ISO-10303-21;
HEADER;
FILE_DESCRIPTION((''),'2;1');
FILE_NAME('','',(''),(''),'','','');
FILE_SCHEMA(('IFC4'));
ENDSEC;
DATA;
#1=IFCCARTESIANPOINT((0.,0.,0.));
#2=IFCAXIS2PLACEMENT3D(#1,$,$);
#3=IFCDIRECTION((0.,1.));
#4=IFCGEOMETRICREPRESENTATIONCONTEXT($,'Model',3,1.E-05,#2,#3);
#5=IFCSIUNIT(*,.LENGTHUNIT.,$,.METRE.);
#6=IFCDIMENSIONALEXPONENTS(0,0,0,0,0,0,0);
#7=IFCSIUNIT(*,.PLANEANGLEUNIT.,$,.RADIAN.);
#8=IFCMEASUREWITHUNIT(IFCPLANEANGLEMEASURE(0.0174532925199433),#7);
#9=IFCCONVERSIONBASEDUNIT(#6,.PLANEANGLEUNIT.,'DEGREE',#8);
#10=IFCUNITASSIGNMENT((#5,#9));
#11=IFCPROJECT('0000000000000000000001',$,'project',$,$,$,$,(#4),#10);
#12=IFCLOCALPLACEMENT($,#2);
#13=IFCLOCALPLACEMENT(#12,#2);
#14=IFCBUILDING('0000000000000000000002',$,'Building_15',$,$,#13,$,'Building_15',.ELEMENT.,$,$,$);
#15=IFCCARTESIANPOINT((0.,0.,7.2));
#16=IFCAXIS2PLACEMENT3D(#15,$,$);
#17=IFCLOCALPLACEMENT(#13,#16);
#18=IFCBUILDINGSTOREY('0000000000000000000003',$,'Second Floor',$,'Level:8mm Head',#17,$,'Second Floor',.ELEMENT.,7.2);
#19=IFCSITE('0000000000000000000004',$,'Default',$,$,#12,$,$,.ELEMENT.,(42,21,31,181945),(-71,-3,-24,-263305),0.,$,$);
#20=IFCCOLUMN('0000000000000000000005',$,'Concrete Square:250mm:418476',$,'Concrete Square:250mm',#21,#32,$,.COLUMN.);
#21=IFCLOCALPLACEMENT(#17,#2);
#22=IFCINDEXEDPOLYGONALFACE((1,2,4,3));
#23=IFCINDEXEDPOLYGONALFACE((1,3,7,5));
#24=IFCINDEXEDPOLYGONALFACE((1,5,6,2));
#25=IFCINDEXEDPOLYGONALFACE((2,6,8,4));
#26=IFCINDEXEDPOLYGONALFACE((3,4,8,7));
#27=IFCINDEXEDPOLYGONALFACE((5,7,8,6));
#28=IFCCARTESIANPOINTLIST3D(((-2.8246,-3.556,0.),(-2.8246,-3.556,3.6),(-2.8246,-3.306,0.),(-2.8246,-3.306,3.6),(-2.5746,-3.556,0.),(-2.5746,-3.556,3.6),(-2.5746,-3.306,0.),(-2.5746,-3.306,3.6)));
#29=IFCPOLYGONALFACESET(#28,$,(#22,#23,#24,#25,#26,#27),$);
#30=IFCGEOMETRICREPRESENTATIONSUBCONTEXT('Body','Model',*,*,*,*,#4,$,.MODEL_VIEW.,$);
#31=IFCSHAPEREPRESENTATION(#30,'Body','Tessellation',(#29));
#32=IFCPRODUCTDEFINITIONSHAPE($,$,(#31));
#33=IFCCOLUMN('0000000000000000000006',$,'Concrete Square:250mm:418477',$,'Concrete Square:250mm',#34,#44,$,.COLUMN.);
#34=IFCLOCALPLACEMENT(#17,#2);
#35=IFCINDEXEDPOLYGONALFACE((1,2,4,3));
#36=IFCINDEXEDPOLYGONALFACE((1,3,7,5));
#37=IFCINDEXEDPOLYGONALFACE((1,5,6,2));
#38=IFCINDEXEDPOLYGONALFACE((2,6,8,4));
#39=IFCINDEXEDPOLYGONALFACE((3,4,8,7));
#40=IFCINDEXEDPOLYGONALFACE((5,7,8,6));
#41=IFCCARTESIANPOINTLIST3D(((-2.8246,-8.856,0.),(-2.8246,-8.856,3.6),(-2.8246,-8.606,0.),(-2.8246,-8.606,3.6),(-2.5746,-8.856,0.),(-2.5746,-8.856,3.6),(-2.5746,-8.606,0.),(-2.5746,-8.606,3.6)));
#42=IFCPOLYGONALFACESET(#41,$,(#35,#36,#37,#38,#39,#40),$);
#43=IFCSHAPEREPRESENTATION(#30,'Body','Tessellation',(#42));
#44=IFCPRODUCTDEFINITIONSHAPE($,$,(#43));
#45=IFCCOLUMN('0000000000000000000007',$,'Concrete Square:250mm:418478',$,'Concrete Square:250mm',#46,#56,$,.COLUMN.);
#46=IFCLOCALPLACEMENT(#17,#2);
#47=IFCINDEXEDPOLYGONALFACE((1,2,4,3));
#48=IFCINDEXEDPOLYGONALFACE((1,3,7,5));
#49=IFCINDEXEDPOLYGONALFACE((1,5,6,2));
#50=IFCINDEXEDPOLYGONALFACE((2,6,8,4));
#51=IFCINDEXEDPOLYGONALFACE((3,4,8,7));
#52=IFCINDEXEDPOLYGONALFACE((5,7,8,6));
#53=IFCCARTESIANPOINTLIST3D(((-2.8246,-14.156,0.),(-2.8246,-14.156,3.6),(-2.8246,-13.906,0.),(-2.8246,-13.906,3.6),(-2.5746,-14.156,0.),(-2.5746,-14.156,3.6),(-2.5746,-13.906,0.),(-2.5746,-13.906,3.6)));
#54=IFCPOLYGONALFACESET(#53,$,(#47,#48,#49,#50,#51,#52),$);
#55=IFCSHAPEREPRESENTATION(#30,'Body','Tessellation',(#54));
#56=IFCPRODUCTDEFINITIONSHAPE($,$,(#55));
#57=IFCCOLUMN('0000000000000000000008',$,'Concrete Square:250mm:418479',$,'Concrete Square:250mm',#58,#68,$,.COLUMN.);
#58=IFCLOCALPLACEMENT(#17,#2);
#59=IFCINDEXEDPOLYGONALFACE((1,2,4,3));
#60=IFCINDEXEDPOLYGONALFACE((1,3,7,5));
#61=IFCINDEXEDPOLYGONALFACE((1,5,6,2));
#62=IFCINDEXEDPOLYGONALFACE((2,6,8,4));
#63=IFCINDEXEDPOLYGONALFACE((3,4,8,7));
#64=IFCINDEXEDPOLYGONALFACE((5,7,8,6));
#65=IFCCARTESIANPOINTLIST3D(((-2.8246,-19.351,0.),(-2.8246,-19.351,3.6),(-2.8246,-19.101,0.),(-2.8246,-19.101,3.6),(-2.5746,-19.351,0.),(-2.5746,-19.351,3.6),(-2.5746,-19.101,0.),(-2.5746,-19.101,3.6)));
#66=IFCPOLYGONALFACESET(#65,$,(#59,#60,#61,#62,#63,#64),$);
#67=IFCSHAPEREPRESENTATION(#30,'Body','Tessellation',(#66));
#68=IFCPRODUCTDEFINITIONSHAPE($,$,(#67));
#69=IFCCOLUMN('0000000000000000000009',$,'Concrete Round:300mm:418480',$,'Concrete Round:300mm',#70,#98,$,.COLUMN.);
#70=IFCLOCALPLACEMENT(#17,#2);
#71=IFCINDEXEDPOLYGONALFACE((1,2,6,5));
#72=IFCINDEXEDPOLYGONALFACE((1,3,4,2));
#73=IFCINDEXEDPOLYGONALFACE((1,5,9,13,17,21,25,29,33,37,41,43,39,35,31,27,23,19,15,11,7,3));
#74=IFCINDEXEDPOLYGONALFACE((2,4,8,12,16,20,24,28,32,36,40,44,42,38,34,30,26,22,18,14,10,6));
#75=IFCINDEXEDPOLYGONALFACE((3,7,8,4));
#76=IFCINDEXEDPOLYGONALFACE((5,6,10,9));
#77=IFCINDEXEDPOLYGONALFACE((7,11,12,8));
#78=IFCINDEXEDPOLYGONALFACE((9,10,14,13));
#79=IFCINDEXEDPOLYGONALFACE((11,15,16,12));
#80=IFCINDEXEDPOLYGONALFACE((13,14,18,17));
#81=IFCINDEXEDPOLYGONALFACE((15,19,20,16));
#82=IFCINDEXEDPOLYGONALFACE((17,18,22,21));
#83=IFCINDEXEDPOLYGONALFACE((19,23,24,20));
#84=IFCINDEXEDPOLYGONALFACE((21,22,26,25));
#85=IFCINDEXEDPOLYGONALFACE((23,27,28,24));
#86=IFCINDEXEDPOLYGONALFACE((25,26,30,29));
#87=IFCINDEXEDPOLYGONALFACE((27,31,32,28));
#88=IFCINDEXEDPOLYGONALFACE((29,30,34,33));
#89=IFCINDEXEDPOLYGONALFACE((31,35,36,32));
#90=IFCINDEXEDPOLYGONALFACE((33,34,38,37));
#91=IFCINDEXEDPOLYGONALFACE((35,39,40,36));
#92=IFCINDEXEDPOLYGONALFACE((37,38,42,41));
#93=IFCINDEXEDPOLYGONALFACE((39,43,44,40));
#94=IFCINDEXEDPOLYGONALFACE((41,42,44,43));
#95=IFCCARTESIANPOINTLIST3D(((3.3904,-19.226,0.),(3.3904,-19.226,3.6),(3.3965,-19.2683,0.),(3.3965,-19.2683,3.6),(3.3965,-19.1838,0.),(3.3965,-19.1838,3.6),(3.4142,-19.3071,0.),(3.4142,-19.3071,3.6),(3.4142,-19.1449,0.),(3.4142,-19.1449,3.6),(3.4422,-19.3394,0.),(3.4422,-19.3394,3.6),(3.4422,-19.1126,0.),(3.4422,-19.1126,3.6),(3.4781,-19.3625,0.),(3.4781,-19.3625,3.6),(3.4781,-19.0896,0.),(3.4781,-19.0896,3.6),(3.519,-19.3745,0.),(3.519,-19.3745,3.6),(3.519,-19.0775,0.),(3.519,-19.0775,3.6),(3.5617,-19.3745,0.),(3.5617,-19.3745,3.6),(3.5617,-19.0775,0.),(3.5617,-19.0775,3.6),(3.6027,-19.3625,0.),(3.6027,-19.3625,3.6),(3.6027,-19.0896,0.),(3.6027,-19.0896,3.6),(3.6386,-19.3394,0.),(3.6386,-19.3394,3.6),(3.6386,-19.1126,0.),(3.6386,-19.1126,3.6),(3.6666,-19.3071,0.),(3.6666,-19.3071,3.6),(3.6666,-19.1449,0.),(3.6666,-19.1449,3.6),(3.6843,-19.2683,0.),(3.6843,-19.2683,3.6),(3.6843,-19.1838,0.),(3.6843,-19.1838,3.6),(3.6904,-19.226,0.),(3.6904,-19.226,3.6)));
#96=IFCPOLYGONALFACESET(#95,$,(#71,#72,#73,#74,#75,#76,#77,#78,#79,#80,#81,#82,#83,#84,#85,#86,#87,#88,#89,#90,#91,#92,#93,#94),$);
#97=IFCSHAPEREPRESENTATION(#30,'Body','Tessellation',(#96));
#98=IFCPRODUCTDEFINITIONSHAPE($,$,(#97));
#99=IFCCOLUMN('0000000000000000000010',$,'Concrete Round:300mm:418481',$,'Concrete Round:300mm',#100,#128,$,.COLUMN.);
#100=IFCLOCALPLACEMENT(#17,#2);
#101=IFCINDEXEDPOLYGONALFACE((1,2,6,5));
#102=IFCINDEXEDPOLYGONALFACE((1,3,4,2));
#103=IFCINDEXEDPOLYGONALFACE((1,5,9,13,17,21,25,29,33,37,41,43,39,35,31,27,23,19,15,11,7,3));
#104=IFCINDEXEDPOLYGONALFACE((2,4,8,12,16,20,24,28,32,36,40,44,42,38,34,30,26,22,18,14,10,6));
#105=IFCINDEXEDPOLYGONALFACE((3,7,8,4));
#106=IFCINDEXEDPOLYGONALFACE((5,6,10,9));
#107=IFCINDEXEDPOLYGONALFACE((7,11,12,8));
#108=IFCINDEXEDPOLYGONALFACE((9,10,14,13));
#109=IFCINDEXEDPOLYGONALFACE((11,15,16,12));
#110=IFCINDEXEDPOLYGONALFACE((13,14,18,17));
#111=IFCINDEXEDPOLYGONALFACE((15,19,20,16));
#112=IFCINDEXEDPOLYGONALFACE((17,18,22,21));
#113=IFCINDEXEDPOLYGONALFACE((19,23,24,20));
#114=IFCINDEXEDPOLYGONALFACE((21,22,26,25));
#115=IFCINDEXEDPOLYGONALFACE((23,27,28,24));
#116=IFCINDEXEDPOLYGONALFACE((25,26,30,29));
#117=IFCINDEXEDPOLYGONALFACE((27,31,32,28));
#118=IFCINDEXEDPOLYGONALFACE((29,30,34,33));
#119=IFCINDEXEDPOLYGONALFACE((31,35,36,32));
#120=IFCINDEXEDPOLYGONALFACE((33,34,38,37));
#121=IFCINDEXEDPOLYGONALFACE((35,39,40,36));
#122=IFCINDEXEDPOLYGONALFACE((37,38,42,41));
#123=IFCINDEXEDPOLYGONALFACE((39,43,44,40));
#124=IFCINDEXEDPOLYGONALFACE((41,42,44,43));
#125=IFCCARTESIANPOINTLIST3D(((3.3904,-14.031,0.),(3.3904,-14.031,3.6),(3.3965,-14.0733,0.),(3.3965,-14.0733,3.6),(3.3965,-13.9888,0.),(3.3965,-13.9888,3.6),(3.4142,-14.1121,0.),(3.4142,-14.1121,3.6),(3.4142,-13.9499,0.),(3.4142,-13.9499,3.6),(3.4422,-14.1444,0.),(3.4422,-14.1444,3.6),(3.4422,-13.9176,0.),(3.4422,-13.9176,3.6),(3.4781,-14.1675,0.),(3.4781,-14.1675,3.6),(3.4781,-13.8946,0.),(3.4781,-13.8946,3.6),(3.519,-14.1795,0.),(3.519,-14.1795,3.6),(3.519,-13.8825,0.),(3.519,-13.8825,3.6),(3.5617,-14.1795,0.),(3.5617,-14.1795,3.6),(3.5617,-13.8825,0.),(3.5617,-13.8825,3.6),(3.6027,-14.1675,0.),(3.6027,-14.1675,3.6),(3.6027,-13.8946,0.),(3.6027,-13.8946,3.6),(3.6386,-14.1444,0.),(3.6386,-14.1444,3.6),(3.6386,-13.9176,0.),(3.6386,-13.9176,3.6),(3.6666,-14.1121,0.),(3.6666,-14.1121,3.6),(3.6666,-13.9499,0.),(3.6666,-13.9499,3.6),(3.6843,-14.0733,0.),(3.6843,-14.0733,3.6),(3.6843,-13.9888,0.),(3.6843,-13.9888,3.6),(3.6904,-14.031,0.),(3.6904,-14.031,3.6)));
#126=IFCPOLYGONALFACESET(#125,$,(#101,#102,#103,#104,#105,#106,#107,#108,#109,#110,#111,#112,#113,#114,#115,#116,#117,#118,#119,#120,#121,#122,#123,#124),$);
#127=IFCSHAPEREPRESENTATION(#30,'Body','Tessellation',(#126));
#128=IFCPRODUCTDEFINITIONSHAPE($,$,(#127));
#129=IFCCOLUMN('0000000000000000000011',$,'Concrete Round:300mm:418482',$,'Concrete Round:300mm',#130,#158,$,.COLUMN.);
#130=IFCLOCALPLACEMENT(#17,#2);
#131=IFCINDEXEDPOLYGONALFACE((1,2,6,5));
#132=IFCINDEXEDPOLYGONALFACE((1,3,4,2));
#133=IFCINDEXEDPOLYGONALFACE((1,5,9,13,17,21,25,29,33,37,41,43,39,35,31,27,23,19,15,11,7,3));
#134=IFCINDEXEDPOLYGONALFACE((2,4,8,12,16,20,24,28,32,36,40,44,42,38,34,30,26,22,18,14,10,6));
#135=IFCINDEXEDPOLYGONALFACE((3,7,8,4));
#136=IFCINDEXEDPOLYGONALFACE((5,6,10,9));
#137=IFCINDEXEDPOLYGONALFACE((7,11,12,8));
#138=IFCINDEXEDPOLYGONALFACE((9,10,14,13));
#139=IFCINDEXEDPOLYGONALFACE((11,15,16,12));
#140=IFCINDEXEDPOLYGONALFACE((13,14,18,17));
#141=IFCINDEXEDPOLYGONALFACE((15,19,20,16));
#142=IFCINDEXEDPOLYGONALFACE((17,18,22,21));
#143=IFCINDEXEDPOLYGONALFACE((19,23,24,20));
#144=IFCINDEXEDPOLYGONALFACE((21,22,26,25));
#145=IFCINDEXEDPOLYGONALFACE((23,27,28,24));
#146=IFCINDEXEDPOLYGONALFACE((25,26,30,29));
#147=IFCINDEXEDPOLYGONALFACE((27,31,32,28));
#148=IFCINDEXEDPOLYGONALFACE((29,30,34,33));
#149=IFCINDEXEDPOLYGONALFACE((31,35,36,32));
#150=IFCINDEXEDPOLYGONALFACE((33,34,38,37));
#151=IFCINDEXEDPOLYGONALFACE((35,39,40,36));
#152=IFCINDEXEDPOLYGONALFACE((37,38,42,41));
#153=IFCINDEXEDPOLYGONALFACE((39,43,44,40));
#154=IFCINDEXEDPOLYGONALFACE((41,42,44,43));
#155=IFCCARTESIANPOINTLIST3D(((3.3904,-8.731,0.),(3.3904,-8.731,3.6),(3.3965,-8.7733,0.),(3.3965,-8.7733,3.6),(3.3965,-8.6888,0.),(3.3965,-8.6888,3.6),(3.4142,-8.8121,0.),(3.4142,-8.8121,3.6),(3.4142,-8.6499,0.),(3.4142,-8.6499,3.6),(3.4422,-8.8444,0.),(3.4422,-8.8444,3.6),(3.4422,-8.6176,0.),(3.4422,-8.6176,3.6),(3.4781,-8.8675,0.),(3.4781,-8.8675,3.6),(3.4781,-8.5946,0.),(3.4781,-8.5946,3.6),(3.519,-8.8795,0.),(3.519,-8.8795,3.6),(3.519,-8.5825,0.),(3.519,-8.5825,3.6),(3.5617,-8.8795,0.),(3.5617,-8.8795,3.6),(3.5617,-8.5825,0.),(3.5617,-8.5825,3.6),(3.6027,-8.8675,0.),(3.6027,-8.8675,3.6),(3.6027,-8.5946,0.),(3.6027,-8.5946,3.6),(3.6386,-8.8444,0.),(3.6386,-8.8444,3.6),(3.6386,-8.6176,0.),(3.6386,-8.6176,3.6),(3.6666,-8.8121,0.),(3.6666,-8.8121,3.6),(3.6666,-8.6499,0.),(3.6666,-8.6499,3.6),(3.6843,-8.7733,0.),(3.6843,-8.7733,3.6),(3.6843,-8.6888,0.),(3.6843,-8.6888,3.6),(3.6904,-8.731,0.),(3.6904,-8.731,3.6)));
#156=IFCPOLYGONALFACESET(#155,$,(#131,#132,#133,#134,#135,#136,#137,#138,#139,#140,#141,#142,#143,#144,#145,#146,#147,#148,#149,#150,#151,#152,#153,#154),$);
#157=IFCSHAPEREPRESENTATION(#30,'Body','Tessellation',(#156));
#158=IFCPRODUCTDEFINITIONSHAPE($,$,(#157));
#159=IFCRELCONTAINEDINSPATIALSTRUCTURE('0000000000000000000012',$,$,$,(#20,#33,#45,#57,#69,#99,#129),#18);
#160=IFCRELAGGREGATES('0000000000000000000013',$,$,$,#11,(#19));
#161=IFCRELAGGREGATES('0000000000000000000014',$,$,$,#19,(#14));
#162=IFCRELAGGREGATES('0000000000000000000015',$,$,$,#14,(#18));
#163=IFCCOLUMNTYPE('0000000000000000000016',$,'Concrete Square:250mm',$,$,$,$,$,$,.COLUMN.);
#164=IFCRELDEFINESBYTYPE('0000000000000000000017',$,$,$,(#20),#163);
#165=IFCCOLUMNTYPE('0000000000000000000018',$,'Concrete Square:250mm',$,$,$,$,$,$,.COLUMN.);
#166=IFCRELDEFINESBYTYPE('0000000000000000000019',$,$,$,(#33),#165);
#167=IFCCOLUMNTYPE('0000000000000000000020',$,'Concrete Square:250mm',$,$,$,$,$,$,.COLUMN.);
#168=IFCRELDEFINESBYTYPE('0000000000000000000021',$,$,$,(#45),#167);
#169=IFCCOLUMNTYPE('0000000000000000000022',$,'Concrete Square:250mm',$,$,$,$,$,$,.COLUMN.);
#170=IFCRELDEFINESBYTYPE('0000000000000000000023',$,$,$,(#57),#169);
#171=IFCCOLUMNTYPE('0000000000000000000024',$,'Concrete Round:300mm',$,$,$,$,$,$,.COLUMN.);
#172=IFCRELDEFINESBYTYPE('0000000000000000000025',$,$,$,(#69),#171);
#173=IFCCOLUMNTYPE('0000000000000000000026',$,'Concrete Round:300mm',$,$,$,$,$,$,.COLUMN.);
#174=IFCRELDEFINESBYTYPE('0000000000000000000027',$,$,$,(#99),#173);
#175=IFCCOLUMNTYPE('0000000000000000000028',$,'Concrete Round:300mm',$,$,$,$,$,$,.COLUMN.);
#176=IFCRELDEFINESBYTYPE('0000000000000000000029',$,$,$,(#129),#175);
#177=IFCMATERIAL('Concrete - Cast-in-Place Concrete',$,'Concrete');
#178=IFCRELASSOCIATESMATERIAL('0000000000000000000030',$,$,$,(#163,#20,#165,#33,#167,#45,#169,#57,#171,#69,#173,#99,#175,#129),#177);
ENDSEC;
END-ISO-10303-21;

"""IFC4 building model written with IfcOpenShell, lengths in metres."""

from ifc_helpers import new_model, entity, si_unit, converted_unit, direction, frame, origin, place, context, subcontext, project, spatial, arc, indexed_curve, outline, extrude, source, transform, mapped, material, type_object, type_shapes, element, save


model = new_model("IFC4")

# Units and contexts
model_context = context("Model", 3, precision=1e-05, world=origin(), true_north=direction((0.0, 1.0)))
body_context = subcontext(model_context, "Body", "Model", "MODEL_VIEW")
ifc_project = project(units=[si_unit("LENGTHUNIT", "METRE"), converted_unit("PLANEANGLEUNIT", "DEGREE", entity("IfcPlaneAngleMeasure", 0.0174532925199433), si_unit("PLANEANGLEUNIT", "RADIAN"), dimensions=[0, 0, 0, 0, 0, 0, 0])], contexts=[model_context])

# Site, building, storey
site_placement = place(None, origin())
site = spatial("IfcSite", under=ifc_project, at=site_placement, Name="Default", CompositionType="ELEMENT", RefLatitude=(42, 21, 31, 181945), RefLongitude=(-71, -3, -24, -263305), RefElevation=0.0)
building_placement = place(site_placement, origin())
building = spatial("IfcBuilding", under=site, at=building_placement, Name="Building_15", LongName="Building_15", CompositionType="ELEMENT")
storey_placement = place(building_placement, frame((0.0, 0.0, 7.2)))
storey = spatial("IfcBuildingStorey", under=building, at=storey_placement, Name="Second Floor", ObjectType="Level:8mm Head", LongName="Second Floor", CompositionType="ELEMENT", Elevation=7.2)

# Columns
ifc_material_1 = material(Name="Concrete - Cast-in-Place Concrete", Category="Concrete")
column_type_1 = type_object("IfcColumnType", Name="Concrete Square:250mm", PredefinedType="COLUMN", material=ifc_material_1)
shared_shape_1 = source(origin(), body_context, "Body", "SweptSolid", [
    extrude(outline(indexed_curve([(-0.125, -0.125), (0.125, -0.125), (0.125, 0.125), (-0.125, 0.125), (-0.125, -0.125)], self_intersect=False)), frame((-2.6996, -3.431, 7.2), z_axis=(0.0, 0.0, 1.0), x_axis=(-1.0, 0.0, 0.0)), (0.0, 0.0, 1.0), 3.6),
])
type_shapes(column_type_1, [shared_shape_1])
column_1_placement = place(storey_placement, frame((0.0, 0.0, -7.2)))
element("IfcColumn", 1, at=column_1_placement, inside=storey, type_object=column_type_1, material=ifc_material_1, Name="Concrete Square:250mm:418476", ObjectType="Concrete Square:250mm", PredefinedType="COLUMN", context=body_context, shape_type="MappedRepresentation", body=[
    mapped(shared_shape_1, transform((0.0, 0.0, 0.0), scale=1.0)),
])
column_type_2 = type_object("IfcColumnType", Name="Concrete Square:250mm", PredefinedType="COLUMN", material=ifc_material_1)
shared_shape_2 = source(origin(), body_context, "Body", "SweptSolid", [
    extrude(outline(indexed_curve([(-0.125, -0.125), (0.125, -0.125), (0.125, 0.125), (-0.125, 0.125), (-0.125, -0.125)], self_intersect=False)), frame((-2.6996, -8.731, 7.2), z_axis=(0.0, 0.0, 1.0), x_axis=(-1.0, 0.0, 0.0)), (0.0, 0.0, 1.0), 3.6),
])
type_shapes(column_type_2, [shared_shape_2])
column_2_placement = place(storey_placement, frame((0.0, 0.0, -7.2)))
element("IfcColumn", 2, at=column_2_placement, inside=storey, type_object=column_type_2, material=ifc_material_1, Name="Concrete Square:250mm:418477", ObjectType="Concrete Square:250mm", PredefinedType="COLUMN", context=body_context, shape_type="MappedRepresentation", body=[
    mapped(shared_shape_2, transform((0.0, 0.0, 0.0), scale=1.0)),
])
column_type_3 = type_object("IfcColumnType", Name="Concrete Square:250mm", PredefinedType="COLUMN", material=ifc_material_1)
shared_shape_3 = source(origin(), body_context, "Body", "SweptSolid", [
    extrude(outline(indexed_curve([(-0.125, -0.125), (0.125, -0.125), (0.125, 0.125), (-0.125, 0.125), (-0.125, -0.125)], self_intersect=False)), frame((-2.6996, -14.031, 7.2), z_axis=(0.0, 0.0, 1.0), x_axis=(-1.0, 0.0, 0.0)), (0.0, 0.0, 1.0), 3.6),
])
type_shapes(column_type_3, [shared_shape_3])
column_3_placement = place(storey_placement, frame((0.0, 0.0, -7.2)))
element("IfcColumn", 3, at=column_3_placement, inside=storey, type_object=column_type_3, material=ifc_material_1, Name="Concrete Square:250mm:418478", ObjectType="Concrete Square:250mm", PredefinedType="COLUMN", context=body_context, shape_type="MappedRepresentation", body=[
    mapped(shared_shape_3, transform((0.0, 0.0, 0.0), scale=1.0)),
])
column_type_4 = type_object("IfcColumnType", Name="Concrete Square:250mm", PredefinedType="COLUMN", material=ifc_material_1)
shared_shape_4 = source(origin(), body_context, "Body", "SweptSolid", [
    extrude(outline(indexed_curve([(-0.125, -0.125), (0.125, -0.125), (0.125, 0.125), (-0.125, 0.125), (-0.125, -0.125)], self_intersect=False)), frame((-2.6996, -19.226, 7.2), z_axis=(0.0, 0.0, 1.0), x_axis=(-1.0, 0.0, 0.0)), (0.0, 0.0, 1.0), 3.6),
])
type_shapes(column_type_4, [shared_shape_4])
column_4_placement = place(storey_placement, frame((0.0, 0.0, -7.2)))
element("IfcColumn", 4, at=column_4_placement, inside=storey, type_object=column_type_4, material=ifc_material_1, Name="Concrete Square:250mm:418479", ObjectType="Concrete Square:250mm", PredefinedType="COLUMN", context=body_context, shape_type="MappedRepresentation", body=[
    mapped(shared_shape_4, transform((0.0, 0.0, 0.0), scale=1.0)),
])
column_type_5 = type_object("IfcColumnType", Name="Concrete Round:300mm", PredefinedType="COLUMN", material=ifc_material_1)
shared_shape_5 = source(origin(), body_context, "Body", "SweptSolid", [
    extrude(outline(indexed_curve([(-0.15, 0.0), (0.0, -0.15), (0.15, 0.0), (0.0, 0.15)], segments=[arc(1, 2, 3), arc(3, 4, 1)], self_intersect=False)), frame((3.5404, -19.226, 7.2)), (0.0, 0.0, 1.0), 3.6),
])
type_shapes(column_type_5, [shared_shape_5])
column_5_placement = place(storey_placement, frame((0.0, 0.0, -7.2)))
element("IfcColumn", 5, at=column_5_placement, inside=storey, type_object=column_type_5, material=ifc_material_1, Name="Concrete Round:300mm:418480", ObjectType="Concrete Round:300mm", PredefinedType="COLUMN", context=body_context, shape_type="MappedRepresentation", body=[
    mapped(shared_shape_5, transform((0.0, 0.0, 0.0), scale=1.0)),
])
column_type_6 = type_object("IfcColumnType", Name="Concrete Round:300mm", PredefinedType="COLUMN", material=ifc_material_1)
shared_shape_6 = source(origin(), body_context, "Body", "SweptSolid", [
    extrude(outline(indexed_curve([(-0.15, 0.0), (0.0, -0.15), (0.15, 0.0), (0.0, 0.15)], segments=[arc(1, 2, 3), arc(3, 4, 1)], self_intersect=False)), frame((3.5404, -14.031, 7.2)), (0.0, 0.0, 1.0), 3.6),
])
type_shapes(column_type_6, [shared_shape_6])
column_6_placement = place(storey_placement, frame((0.0, 0.0, -7.2)))
element("IfcColumn", 6, at=column_6_placement, inside=storey, type_object=column_type_6, material=ifc_material_1, Name="Concrete Round:300mm:418481", ObjectType="Concrete Round:300mm", PredefinedType="COLUMN", context=body_context, shape_type="MappedRepresentation", body=[
    mapped(shared_shape_6, transform((0.0, 0.0, 0.0), scale=1.0)),
])
column_type_7 = type_object("IfcColumnType", Name="Concrete Round:300mm", PredefinedType="COLUMN", material=ifc_material_1)
shared_shape_7 = source(origin(), body_context, "Body", "SweptSolid", [
    extrude(outline(indexed_curve([(-0.15, 0.0), (0.0, -0.15), (0.15, 0.0), (0.0, 0.15)], segments=[arc(1, 2, 3), arc(3, 4, 1)], self_intersect=False)), frame((3.5404, -8.731, 7.2)), (0.0, 0.0, 1.0), 3.6),
])
type_shapes(column_type_7, [shared_shape_7])
column_7_placement = place(storey_placement, frame((0.0, 0.0, -7.2)))
element("IfcColumn", 7, at=column_7_placement, inside=storey, type_object=column_type_7, material=ifc_material_1, Name="Concrete Round:300mm:418482", ObjectType="Concrete Round:300mm", PredefinedType="COLUMN", context=body_context, shape_type="MappedRepresentation", body=[
    mapped(shared_shape_7, transform((0.0, 0.0, 0.0), scale=1.0)),
])

save(model, "model.ifc")
